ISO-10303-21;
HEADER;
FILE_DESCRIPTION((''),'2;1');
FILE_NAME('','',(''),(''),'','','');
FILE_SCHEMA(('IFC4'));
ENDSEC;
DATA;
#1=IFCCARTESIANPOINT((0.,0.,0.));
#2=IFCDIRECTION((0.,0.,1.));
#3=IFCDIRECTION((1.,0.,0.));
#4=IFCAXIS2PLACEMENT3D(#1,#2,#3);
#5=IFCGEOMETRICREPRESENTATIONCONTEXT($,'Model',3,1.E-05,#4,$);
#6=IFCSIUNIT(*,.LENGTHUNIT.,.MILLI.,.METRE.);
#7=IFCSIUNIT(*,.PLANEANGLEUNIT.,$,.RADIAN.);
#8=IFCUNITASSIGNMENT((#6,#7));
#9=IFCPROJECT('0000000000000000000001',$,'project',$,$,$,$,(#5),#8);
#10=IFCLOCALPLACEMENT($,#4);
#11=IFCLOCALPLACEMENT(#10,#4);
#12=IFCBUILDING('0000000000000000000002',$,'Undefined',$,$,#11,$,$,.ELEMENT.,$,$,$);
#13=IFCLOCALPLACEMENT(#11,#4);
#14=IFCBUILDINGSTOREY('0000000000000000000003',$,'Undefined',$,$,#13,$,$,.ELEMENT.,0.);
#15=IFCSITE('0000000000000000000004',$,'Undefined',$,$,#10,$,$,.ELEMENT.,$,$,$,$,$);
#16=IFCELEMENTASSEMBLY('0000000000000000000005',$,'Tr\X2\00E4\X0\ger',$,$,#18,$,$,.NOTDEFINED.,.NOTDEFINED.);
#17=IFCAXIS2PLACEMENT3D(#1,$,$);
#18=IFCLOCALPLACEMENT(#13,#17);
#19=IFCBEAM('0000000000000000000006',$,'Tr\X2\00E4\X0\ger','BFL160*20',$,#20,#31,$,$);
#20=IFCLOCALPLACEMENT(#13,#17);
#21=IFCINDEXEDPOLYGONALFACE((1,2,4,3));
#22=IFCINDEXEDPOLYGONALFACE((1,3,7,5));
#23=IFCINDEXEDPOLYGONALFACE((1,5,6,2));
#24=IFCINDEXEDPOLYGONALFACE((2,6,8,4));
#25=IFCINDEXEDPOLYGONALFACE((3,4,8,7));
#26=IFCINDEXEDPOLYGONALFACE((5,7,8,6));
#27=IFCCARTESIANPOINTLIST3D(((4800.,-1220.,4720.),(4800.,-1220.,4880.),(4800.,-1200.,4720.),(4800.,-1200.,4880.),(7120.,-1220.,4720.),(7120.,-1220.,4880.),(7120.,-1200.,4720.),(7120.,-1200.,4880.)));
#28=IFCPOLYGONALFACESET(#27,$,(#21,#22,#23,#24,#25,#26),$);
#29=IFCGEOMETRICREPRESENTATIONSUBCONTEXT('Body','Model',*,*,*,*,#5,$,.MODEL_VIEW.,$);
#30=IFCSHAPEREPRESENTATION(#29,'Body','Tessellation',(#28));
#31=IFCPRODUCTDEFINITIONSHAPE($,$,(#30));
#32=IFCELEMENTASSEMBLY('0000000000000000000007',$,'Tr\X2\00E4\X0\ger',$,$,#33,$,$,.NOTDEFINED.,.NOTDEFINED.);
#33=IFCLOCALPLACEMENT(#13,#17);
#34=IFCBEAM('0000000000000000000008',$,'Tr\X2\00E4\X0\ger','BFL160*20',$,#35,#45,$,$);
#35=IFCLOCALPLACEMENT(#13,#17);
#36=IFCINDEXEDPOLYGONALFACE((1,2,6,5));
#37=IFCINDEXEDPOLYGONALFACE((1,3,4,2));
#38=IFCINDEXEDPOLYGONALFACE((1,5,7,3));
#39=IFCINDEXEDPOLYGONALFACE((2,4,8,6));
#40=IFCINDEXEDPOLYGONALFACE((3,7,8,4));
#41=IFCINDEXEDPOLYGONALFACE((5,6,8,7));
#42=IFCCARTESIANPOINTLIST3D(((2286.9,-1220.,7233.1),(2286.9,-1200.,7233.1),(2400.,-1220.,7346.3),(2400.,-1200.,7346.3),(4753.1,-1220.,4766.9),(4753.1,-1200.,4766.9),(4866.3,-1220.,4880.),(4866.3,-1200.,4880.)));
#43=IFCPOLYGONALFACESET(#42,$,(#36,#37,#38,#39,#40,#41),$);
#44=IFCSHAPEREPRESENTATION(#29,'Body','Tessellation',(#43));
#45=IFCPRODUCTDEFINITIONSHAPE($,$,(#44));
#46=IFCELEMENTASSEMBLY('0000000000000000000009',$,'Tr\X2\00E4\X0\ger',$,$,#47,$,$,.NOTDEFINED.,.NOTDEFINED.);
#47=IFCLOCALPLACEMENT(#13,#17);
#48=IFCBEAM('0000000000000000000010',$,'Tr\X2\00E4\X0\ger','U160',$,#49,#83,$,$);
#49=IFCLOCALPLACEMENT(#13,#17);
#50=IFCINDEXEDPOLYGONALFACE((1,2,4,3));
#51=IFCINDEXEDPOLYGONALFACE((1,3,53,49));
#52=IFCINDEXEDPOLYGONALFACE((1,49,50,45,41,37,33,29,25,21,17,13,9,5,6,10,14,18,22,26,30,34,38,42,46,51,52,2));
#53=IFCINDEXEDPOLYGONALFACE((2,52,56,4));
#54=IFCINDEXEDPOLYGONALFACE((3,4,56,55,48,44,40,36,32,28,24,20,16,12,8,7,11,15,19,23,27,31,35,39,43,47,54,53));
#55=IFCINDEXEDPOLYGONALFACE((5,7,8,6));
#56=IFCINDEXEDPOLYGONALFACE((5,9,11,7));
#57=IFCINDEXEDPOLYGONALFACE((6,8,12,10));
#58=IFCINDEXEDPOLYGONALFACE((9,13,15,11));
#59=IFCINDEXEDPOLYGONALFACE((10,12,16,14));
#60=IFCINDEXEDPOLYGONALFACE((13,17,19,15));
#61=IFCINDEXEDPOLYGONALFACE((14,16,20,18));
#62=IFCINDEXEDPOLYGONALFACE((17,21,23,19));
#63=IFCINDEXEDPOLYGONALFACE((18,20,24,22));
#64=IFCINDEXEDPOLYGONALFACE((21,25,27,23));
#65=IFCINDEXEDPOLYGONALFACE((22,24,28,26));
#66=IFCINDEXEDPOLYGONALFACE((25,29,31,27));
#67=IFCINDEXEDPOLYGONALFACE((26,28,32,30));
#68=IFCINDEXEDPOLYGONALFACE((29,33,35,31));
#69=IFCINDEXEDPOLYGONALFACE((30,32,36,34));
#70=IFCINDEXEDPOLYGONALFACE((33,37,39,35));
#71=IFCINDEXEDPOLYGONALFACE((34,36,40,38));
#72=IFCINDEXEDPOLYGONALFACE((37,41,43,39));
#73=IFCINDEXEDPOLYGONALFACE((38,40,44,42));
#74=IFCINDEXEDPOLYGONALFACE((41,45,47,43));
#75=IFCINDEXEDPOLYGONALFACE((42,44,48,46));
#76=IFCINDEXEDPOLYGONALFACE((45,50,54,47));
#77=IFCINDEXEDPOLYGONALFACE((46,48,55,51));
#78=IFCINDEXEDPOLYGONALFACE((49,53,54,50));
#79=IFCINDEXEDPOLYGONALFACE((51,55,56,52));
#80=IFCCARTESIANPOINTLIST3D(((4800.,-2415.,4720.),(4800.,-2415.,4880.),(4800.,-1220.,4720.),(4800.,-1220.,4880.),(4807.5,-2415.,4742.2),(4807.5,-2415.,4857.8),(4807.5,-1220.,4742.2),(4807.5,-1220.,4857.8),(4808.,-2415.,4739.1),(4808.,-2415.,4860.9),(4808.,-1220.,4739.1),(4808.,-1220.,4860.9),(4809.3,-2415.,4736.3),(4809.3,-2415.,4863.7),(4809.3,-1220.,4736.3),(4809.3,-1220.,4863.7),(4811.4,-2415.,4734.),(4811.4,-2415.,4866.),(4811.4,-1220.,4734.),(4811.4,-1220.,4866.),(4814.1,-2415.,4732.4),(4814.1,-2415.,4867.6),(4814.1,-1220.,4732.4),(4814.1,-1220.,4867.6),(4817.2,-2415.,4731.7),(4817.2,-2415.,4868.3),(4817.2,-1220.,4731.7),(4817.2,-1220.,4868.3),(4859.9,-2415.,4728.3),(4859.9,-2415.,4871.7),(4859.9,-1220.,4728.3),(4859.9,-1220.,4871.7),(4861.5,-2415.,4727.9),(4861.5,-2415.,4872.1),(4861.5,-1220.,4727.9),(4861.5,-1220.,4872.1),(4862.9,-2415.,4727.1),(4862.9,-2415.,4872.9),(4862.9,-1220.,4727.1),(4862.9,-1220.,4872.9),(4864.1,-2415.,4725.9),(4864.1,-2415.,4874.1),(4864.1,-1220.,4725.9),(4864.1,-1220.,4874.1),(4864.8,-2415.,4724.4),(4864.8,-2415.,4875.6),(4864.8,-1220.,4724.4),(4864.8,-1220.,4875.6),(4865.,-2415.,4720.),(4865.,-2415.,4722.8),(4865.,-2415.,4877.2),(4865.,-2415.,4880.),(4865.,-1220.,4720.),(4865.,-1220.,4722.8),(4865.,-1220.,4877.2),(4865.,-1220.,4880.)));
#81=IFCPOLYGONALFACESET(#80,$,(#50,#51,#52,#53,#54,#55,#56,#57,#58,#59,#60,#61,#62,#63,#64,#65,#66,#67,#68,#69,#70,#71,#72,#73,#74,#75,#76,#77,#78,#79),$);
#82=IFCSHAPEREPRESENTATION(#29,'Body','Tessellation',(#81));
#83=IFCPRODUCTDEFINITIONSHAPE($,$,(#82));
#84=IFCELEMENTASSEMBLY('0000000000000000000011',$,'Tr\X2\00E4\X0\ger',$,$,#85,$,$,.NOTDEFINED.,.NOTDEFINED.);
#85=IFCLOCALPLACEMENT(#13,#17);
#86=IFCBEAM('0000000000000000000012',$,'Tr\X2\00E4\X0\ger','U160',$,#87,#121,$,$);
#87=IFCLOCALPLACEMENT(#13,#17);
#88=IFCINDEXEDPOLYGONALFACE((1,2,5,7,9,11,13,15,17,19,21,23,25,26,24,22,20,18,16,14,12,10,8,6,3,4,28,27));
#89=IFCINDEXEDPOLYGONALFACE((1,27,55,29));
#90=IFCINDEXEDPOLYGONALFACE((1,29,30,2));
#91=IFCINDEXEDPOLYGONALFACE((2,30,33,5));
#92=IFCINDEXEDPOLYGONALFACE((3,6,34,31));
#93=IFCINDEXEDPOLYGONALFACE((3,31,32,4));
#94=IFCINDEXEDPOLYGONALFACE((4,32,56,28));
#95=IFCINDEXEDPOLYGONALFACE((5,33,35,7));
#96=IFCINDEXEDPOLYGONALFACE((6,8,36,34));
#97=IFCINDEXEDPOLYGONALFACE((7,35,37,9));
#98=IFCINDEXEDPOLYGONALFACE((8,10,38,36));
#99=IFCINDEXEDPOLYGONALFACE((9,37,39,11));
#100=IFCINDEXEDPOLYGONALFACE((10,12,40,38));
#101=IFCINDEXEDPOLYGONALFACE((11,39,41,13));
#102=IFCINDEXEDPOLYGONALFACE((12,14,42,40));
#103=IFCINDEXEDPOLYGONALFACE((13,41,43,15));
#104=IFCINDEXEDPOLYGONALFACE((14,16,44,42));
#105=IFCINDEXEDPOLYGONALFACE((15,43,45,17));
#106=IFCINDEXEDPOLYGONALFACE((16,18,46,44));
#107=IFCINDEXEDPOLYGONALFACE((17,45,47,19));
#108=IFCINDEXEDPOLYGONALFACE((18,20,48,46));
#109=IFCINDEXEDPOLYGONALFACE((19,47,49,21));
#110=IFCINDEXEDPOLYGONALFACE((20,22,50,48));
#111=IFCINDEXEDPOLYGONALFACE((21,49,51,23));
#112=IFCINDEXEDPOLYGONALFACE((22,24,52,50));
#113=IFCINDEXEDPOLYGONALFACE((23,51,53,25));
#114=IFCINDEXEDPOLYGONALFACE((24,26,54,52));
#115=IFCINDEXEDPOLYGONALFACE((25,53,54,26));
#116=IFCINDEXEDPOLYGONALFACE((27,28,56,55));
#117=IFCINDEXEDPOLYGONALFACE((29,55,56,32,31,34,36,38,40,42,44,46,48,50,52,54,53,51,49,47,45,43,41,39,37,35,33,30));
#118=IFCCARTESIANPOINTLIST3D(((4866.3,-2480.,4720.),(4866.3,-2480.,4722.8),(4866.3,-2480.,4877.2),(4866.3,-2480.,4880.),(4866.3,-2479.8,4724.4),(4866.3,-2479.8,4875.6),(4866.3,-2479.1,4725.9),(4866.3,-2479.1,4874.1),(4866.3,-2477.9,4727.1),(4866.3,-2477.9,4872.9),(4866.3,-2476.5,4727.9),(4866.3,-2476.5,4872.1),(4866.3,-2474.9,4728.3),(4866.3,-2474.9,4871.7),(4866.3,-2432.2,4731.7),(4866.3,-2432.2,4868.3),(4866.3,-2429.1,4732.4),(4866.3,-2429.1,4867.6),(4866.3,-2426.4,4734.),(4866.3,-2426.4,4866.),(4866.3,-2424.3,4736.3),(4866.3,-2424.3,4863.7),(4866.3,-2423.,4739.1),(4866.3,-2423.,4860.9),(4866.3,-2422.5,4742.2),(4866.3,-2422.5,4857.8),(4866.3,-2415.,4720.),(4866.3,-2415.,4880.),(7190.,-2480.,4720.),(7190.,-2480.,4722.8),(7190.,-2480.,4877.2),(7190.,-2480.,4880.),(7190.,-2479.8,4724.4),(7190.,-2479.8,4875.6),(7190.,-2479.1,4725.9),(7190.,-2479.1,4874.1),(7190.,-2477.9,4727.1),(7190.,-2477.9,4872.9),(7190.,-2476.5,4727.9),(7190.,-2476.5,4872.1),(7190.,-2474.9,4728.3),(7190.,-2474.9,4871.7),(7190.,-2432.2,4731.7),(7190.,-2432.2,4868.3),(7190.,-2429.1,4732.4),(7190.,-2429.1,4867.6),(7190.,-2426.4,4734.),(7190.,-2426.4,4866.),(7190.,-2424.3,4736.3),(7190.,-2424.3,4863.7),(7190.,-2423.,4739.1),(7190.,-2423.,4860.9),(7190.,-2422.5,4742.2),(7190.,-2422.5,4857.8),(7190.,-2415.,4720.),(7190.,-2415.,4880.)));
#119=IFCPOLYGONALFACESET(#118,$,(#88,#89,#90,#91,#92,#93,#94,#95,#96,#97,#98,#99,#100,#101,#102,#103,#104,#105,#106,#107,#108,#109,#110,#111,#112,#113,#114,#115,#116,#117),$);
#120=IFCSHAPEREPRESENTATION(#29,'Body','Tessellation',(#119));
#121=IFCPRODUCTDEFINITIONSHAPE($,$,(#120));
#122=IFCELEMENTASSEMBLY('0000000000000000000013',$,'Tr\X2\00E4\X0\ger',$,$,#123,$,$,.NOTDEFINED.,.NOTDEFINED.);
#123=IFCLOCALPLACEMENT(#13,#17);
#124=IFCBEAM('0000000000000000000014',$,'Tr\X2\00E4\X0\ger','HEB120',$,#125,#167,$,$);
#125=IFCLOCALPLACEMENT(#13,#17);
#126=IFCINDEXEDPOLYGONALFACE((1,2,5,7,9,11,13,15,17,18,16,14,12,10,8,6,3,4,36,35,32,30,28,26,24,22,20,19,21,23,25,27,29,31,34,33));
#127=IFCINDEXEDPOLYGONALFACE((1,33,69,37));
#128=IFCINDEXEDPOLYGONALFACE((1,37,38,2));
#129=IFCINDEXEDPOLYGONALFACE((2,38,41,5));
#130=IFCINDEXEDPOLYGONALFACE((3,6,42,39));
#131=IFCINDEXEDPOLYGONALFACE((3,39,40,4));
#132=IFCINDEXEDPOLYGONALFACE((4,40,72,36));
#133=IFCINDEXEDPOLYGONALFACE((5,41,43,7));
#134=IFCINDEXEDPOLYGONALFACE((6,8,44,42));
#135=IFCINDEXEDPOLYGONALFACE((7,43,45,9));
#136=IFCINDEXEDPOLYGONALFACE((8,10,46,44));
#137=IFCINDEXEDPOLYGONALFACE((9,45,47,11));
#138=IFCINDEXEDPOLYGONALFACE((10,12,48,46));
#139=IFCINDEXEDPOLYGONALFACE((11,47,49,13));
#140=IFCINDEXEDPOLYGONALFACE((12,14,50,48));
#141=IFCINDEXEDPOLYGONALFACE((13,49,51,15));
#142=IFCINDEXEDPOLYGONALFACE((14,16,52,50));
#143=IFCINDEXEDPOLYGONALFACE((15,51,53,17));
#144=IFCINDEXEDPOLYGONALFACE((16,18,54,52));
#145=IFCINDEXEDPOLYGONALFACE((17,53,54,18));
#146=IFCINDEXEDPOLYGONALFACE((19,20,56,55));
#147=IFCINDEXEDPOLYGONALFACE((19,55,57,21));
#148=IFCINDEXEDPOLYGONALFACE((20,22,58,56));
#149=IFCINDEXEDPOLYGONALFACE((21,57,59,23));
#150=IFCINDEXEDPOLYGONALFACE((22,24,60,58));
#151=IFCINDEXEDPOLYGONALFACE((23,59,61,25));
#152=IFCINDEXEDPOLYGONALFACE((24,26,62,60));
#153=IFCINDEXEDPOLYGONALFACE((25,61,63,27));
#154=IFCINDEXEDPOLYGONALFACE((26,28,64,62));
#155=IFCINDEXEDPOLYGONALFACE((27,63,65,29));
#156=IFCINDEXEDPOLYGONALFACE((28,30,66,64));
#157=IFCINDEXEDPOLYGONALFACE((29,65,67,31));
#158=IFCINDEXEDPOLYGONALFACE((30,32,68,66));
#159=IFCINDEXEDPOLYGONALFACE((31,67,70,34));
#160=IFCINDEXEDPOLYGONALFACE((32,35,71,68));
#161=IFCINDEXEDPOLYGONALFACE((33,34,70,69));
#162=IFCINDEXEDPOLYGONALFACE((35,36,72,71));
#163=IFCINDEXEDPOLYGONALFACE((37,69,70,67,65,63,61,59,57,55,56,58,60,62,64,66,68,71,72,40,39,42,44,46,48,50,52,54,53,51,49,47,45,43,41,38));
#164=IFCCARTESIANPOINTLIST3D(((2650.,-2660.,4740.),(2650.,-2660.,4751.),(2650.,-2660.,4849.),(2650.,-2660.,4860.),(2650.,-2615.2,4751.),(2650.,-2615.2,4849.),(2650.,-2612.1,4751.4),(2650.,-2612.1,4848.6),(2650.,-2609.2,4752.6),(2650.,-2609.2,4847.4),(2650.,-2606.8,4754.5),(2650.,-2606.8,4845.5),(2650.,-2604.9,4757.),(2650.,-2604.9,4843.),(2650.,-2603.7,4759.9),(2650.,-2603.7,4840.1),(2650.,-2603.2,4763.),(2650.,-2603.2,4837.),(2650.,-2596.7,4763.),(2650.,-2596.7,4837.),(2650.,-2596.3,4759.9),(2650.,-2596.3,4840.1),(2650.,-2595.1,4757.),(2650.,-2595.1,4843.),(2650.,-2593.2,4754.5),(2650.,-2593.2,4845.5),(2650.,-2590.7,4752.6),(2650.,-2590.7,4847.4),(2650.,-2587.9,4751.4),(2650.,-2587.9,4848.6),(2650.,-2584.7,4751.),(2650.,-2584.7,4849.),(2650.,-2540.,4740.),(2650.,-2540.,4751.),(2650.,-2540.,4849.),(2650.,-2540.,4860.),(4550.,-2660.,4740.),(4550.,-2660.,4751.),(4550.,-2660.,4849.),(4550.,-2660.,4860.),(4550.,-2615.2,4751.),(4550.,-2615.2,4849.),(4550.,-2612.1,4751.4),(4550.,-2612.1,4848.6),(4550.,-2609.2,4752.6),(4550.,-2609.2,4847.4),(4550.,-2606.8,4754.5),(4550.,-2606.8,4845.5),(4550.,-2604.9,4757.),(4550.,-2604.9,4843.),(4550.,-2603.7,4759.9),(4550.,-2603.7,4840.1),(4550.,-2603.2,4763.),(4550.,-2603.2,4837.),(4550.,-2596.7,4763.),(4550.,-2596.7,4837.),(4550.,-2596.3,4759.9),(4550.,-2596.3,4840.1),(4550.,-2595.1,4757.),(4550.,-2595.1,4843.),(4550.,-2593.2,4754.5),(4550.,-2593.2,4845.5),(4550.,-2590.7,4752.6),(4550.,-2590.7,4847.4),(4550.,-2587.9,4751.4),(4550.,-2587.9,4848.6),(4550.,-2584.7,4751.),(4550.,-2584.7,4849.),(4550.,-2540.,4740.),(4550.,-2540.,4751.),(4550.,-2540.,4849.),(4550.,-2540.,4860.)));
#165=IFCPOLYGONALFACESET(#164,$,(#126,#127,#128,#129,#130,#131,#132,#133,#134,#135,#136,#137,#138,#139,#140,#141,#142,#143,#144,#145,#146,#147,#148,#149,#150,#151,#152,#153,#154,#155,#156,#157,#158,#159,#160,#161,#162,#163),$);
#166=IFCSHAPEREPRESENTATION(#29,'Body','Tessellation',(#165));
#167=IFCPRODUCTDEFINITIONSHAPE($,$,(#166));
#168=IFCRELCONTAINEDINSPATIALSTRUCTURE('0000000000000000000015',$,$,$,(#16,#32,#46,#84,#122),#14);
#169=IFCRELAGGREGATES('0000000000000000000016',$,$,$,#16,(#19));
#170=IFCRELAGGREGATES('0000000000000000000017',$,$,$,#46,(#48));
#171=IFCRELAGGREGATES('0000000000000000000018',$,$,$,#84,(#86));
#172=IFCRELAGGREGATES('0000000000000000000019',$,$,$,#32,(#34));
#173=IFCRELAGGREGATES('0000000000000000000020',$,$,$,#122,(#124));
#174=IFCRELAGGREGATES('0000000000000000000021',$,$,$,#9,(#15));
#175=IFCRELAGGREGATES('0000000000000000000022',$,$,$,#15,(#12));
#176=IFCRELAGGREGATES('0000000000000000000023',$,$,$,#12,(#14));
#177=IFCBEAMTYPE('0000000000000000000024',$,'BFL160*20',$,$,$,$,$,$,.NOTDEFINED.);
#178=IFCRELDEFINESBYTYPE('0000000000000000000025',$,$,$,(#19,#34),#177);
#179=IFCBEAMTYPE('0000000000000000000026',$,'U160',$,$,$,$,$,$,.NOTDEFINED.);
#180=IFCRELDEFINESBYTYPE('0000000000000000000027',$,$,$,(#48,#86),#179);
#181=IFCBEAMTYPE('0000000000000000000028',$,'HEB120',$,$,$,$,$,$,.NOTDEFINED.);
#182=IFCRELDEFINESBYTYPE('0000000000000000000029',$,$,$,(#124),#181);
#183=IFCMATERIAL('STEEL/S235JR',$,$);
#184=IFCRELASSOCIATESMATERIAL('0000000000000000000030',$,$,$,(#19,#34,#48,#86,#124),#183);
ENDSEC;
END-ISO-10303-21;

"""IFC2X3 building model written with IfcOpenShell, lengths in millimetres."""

from ifc_helpers import new_model, si_unit, frame, origin_with_axes, origin_2d_with_axis, place, context, subcontext, project, spatial, rectangle, i_section, u_section, extrude, clip, halfspace, material, type_object, element, aggregate, save


model = new_model("IFC2X3")

# Units and contexts
model_context = context("Model", 3, precision=1e-05, world=origin_with_axes())
body_context = subcontext(model_context, "Body", "Model", "MODEL_VIEW")
ifc_project = project(units=[si_unit("LENGTHUNIT", "METRE", prefix="MILLI"), si_unit("PLANEANGLEUNIT", "RADIAN")], contexts=[model_context])

# Site, building, storey
site_placement = place(None, origin_with_axes())
site = spatial("IfcSite", under=ifc_project, at=site_placement, Name="Undefined", CompositionType="ELEMENT")
building_placement = place(site_placement, origin_with_axes())
building = spatial("IfcBuilding", under=site, at=building_placement, Name="Undefined", CompositionType="ELEMENT")
storey_placement = place(building_placement, origin_with_axes())
storey = spatial("IfcBuildingStorey", under=building, at=storey_placement, Name="Undefined", CompositionType="ELEMENT", Elevation=0.0)

# Element assemblies, beams
assembly_1_placement = place(storey_placement, origin_with_axes())
assembly_1 = element("IfcElementAssembly", 1, at=assembly_1_placement, inside=storey, Name="Träger", AssemblyPlace="NOTDEFINED", PredefinedType="NOTDEFINED")
ifc_material_1 = material(Name="STEEL/S235JR")
beam_type_1 = type_object("IfcBeamType", Name="BFL160*20", PredefinedType="NOTDEFINED")
beam_1_placement = place(assembly_1_placement, frame((4800.0, -1210.0, 4800.0), z_axis=(0.0, 0.0, 1.0), x_axis=(1.0, 0.0, 0.0)))
beam_1 = element("IfcBeam", 2, at=beam_1_placement, type_object=beam_type_1, material=ifc_material_1, Name="Träger", Description="BFL160*20", context=body_context, shape_type="SweptSolid", body=[
    extrude(rectangle(XDim=20.0, YDim=160.0, at=origin_2d_with_axis()), frame((2320.0, 0.0, 0.0), z_axis=(-1.0, 0.0, 0.0), x_axis=(0.0, -1.0, 0.0)), (0.0, 0.0, 1.0), 2320.0),
])
aggregate(assembly_1, [beam_1])
assembly_2_placement = place(storey_placement, origin_with_axes())
assembly_2 = element("IfcElementAssembly", 3, at=assembly_2_placement, inside=storey, Name="Träger", AssemblyPlace="NOTDEFINED", PredefinedType="NOTDEFINED")
beam_2_placement = place(assembly_2_placement, frame((4809.7, -1210.0, 4823.4), z_axis=(0.707107, 0.0, 0.707107), x_axis=(-0.707107, 0.0, 0.707107)))
beam_2 = element("IfcBeam", 4, at=beam_2_placement, type_object=beam_type_1, material=ifc_material_1, Name="Träger", Description="BFL160*20", context=body_context, shape_type="SweptSolid", body=[
    extrude(rectangle(XDim=20.0, YDim=160.0, at=origin_2d_with_axis()), frame((3487.8, 0.0, 0.0), z_axis=(-1.0, 0.0, 0.0), x_axis=(0.0, -1.0, 0.0)), (0.0, 0.0, 1.0), 3487.8),
])
assembly_3_placement = place(storey_placement, origin_with_axes())
assembly_3 = element("IfcElementAssembly", 5, at=assembly_3_placement, inside=storey, Name="Träger", AssemblyPlace="NOTDEFINED", PredefinedType="NOTDEFINED")
beam_type_2 = type_object("IfcBeamType", Name="U160", PredefinedType="NOTDEFINED")
beam_3_placement = place(assembly_3_placement, frame((4832.5, -1220.0, 4800.0), z_axis=(0.0, 0.0, -1.0), x_axis=(0.0, -1.0, 0.0)))
beam_3 = element("IfcBeam", 6, at=beam_3_placement, type_object=beam_type_2, material=ifc_material_1, Name="Träger", Description="U160", context=body_context, shape_type="SweptSolid", body=[
    extrude(u_section(Depth=160.0, FlangeWidth=65.0, WebThickness=7.5, FlangeThickness=10.5, FilletRadius=10.5, EdgeRadius=5.5, FlangeSlope=0.07983, at=origin_2d_with_axis()), frame((1195.0, 0.0, 0.0), z_axis=(-1.0, 0.0, 0.0), x_axis=(0.0, -1.0, 0.0)), (0.0, 0.0, 1.0), 1195.0),
])
aggregate(assembly_3, [beam_3])
assembly_4_placement = place(storey_placement, origin_with_axes())
assembly_4 = element("IfcElementAssembly", 7, at=assembly_4_placement, inside=storey, Name="Träger", AssemblyPlace="NOTDEFINED", PredefinedType="NOTDEFINED")
beam_4_placement = place(assembly_4_placement, frame((4866.3, -2447.5, 4800.0), z_axis=(0.0, 0.0, 1.0), x_axis=(1.0, 0.0, 0.0)))
beam_4 = element("IfcBeam", 8, at=beam_4_placement, type_object=beam_type_2, material=ifc_material_1, Name="Träger", Description="U160", context=body_context, shape_type="SweptSolid", body=[
    extrude(u_section(Depth=160.0, FlangeWidth=65.0, WebThickness=7.5, FlangeThickness=10.5, FilletRadius=10.5, EdgeRadius=5.5, FlangeSlope=0.07983, at=origin_2d_with_axis()), frame((2323.7, 0.0, 0.0), z_axis=(-1.0, 0.0, 0.0), x_axis=(0.0, -1.0, 0.0)), (0.0, 0.0, 1.0), 2323.7),
])
aggregate(assembly_4, [beam_4])
beam_type_3 = type_object("IfcBeamType", Name="HEB120", PredefinedType="NOTDEFINED")
assembly_5_placement = place(storey_placement, origin_with_axes())
assembly_5 = element("IfcElementAssembly", 9, at=assembly_5_placement, inside=storey, Name="Träger", AssemblyPlace="NOTDEFINED", PredefinedType="NOTDEFINED")
beam_5_placement = place(assembly_5_placement, frame((4550.0, -2600.0, 4800.0), z_axis=(0.0, 0.0, 1.0), x_axis=(-1.0, 0.0, 0.0)))
beam_5 = element("IfcBeam", 10, at=beam_5_placement, type_object=beam_type_3, material=ifc_material_1, Name="Träger", Description="HEB120", context=body_context, shape_type="Clipping", body=[
    clip(clip(extrude(i_section(OverallWidth=120.0, OverallDepth=120.0, WebThickness=6.5, FlangeThickness=11.0, FilletRadius=12.0, at=origin_2d_with_axis()), frame((1910.0, 0.0, 0.0), z_axis=(-1.0, 0.0, 0.0), x_axis=(0.0, -1.0, 0.0)), (0.0, 0.0, 1.0), 1910.0), halfspace(frame((1900.0, 0.0, -60.0), z_axis=(-1.0, 0.0, 0.0), x_axis=(0.0, 1.0, 0.0)), True)), halfspace(frame((0.0, 0.0, -60.0), z_axis=(1.0, 0.0, 0.0), x_axis=(0.0, -1.0, 0.0)), True)),
])

aggregate(assembly_2, [beam_2])
aggregate(assembly_5, [beam_5])

save(model, "model.ifc")
